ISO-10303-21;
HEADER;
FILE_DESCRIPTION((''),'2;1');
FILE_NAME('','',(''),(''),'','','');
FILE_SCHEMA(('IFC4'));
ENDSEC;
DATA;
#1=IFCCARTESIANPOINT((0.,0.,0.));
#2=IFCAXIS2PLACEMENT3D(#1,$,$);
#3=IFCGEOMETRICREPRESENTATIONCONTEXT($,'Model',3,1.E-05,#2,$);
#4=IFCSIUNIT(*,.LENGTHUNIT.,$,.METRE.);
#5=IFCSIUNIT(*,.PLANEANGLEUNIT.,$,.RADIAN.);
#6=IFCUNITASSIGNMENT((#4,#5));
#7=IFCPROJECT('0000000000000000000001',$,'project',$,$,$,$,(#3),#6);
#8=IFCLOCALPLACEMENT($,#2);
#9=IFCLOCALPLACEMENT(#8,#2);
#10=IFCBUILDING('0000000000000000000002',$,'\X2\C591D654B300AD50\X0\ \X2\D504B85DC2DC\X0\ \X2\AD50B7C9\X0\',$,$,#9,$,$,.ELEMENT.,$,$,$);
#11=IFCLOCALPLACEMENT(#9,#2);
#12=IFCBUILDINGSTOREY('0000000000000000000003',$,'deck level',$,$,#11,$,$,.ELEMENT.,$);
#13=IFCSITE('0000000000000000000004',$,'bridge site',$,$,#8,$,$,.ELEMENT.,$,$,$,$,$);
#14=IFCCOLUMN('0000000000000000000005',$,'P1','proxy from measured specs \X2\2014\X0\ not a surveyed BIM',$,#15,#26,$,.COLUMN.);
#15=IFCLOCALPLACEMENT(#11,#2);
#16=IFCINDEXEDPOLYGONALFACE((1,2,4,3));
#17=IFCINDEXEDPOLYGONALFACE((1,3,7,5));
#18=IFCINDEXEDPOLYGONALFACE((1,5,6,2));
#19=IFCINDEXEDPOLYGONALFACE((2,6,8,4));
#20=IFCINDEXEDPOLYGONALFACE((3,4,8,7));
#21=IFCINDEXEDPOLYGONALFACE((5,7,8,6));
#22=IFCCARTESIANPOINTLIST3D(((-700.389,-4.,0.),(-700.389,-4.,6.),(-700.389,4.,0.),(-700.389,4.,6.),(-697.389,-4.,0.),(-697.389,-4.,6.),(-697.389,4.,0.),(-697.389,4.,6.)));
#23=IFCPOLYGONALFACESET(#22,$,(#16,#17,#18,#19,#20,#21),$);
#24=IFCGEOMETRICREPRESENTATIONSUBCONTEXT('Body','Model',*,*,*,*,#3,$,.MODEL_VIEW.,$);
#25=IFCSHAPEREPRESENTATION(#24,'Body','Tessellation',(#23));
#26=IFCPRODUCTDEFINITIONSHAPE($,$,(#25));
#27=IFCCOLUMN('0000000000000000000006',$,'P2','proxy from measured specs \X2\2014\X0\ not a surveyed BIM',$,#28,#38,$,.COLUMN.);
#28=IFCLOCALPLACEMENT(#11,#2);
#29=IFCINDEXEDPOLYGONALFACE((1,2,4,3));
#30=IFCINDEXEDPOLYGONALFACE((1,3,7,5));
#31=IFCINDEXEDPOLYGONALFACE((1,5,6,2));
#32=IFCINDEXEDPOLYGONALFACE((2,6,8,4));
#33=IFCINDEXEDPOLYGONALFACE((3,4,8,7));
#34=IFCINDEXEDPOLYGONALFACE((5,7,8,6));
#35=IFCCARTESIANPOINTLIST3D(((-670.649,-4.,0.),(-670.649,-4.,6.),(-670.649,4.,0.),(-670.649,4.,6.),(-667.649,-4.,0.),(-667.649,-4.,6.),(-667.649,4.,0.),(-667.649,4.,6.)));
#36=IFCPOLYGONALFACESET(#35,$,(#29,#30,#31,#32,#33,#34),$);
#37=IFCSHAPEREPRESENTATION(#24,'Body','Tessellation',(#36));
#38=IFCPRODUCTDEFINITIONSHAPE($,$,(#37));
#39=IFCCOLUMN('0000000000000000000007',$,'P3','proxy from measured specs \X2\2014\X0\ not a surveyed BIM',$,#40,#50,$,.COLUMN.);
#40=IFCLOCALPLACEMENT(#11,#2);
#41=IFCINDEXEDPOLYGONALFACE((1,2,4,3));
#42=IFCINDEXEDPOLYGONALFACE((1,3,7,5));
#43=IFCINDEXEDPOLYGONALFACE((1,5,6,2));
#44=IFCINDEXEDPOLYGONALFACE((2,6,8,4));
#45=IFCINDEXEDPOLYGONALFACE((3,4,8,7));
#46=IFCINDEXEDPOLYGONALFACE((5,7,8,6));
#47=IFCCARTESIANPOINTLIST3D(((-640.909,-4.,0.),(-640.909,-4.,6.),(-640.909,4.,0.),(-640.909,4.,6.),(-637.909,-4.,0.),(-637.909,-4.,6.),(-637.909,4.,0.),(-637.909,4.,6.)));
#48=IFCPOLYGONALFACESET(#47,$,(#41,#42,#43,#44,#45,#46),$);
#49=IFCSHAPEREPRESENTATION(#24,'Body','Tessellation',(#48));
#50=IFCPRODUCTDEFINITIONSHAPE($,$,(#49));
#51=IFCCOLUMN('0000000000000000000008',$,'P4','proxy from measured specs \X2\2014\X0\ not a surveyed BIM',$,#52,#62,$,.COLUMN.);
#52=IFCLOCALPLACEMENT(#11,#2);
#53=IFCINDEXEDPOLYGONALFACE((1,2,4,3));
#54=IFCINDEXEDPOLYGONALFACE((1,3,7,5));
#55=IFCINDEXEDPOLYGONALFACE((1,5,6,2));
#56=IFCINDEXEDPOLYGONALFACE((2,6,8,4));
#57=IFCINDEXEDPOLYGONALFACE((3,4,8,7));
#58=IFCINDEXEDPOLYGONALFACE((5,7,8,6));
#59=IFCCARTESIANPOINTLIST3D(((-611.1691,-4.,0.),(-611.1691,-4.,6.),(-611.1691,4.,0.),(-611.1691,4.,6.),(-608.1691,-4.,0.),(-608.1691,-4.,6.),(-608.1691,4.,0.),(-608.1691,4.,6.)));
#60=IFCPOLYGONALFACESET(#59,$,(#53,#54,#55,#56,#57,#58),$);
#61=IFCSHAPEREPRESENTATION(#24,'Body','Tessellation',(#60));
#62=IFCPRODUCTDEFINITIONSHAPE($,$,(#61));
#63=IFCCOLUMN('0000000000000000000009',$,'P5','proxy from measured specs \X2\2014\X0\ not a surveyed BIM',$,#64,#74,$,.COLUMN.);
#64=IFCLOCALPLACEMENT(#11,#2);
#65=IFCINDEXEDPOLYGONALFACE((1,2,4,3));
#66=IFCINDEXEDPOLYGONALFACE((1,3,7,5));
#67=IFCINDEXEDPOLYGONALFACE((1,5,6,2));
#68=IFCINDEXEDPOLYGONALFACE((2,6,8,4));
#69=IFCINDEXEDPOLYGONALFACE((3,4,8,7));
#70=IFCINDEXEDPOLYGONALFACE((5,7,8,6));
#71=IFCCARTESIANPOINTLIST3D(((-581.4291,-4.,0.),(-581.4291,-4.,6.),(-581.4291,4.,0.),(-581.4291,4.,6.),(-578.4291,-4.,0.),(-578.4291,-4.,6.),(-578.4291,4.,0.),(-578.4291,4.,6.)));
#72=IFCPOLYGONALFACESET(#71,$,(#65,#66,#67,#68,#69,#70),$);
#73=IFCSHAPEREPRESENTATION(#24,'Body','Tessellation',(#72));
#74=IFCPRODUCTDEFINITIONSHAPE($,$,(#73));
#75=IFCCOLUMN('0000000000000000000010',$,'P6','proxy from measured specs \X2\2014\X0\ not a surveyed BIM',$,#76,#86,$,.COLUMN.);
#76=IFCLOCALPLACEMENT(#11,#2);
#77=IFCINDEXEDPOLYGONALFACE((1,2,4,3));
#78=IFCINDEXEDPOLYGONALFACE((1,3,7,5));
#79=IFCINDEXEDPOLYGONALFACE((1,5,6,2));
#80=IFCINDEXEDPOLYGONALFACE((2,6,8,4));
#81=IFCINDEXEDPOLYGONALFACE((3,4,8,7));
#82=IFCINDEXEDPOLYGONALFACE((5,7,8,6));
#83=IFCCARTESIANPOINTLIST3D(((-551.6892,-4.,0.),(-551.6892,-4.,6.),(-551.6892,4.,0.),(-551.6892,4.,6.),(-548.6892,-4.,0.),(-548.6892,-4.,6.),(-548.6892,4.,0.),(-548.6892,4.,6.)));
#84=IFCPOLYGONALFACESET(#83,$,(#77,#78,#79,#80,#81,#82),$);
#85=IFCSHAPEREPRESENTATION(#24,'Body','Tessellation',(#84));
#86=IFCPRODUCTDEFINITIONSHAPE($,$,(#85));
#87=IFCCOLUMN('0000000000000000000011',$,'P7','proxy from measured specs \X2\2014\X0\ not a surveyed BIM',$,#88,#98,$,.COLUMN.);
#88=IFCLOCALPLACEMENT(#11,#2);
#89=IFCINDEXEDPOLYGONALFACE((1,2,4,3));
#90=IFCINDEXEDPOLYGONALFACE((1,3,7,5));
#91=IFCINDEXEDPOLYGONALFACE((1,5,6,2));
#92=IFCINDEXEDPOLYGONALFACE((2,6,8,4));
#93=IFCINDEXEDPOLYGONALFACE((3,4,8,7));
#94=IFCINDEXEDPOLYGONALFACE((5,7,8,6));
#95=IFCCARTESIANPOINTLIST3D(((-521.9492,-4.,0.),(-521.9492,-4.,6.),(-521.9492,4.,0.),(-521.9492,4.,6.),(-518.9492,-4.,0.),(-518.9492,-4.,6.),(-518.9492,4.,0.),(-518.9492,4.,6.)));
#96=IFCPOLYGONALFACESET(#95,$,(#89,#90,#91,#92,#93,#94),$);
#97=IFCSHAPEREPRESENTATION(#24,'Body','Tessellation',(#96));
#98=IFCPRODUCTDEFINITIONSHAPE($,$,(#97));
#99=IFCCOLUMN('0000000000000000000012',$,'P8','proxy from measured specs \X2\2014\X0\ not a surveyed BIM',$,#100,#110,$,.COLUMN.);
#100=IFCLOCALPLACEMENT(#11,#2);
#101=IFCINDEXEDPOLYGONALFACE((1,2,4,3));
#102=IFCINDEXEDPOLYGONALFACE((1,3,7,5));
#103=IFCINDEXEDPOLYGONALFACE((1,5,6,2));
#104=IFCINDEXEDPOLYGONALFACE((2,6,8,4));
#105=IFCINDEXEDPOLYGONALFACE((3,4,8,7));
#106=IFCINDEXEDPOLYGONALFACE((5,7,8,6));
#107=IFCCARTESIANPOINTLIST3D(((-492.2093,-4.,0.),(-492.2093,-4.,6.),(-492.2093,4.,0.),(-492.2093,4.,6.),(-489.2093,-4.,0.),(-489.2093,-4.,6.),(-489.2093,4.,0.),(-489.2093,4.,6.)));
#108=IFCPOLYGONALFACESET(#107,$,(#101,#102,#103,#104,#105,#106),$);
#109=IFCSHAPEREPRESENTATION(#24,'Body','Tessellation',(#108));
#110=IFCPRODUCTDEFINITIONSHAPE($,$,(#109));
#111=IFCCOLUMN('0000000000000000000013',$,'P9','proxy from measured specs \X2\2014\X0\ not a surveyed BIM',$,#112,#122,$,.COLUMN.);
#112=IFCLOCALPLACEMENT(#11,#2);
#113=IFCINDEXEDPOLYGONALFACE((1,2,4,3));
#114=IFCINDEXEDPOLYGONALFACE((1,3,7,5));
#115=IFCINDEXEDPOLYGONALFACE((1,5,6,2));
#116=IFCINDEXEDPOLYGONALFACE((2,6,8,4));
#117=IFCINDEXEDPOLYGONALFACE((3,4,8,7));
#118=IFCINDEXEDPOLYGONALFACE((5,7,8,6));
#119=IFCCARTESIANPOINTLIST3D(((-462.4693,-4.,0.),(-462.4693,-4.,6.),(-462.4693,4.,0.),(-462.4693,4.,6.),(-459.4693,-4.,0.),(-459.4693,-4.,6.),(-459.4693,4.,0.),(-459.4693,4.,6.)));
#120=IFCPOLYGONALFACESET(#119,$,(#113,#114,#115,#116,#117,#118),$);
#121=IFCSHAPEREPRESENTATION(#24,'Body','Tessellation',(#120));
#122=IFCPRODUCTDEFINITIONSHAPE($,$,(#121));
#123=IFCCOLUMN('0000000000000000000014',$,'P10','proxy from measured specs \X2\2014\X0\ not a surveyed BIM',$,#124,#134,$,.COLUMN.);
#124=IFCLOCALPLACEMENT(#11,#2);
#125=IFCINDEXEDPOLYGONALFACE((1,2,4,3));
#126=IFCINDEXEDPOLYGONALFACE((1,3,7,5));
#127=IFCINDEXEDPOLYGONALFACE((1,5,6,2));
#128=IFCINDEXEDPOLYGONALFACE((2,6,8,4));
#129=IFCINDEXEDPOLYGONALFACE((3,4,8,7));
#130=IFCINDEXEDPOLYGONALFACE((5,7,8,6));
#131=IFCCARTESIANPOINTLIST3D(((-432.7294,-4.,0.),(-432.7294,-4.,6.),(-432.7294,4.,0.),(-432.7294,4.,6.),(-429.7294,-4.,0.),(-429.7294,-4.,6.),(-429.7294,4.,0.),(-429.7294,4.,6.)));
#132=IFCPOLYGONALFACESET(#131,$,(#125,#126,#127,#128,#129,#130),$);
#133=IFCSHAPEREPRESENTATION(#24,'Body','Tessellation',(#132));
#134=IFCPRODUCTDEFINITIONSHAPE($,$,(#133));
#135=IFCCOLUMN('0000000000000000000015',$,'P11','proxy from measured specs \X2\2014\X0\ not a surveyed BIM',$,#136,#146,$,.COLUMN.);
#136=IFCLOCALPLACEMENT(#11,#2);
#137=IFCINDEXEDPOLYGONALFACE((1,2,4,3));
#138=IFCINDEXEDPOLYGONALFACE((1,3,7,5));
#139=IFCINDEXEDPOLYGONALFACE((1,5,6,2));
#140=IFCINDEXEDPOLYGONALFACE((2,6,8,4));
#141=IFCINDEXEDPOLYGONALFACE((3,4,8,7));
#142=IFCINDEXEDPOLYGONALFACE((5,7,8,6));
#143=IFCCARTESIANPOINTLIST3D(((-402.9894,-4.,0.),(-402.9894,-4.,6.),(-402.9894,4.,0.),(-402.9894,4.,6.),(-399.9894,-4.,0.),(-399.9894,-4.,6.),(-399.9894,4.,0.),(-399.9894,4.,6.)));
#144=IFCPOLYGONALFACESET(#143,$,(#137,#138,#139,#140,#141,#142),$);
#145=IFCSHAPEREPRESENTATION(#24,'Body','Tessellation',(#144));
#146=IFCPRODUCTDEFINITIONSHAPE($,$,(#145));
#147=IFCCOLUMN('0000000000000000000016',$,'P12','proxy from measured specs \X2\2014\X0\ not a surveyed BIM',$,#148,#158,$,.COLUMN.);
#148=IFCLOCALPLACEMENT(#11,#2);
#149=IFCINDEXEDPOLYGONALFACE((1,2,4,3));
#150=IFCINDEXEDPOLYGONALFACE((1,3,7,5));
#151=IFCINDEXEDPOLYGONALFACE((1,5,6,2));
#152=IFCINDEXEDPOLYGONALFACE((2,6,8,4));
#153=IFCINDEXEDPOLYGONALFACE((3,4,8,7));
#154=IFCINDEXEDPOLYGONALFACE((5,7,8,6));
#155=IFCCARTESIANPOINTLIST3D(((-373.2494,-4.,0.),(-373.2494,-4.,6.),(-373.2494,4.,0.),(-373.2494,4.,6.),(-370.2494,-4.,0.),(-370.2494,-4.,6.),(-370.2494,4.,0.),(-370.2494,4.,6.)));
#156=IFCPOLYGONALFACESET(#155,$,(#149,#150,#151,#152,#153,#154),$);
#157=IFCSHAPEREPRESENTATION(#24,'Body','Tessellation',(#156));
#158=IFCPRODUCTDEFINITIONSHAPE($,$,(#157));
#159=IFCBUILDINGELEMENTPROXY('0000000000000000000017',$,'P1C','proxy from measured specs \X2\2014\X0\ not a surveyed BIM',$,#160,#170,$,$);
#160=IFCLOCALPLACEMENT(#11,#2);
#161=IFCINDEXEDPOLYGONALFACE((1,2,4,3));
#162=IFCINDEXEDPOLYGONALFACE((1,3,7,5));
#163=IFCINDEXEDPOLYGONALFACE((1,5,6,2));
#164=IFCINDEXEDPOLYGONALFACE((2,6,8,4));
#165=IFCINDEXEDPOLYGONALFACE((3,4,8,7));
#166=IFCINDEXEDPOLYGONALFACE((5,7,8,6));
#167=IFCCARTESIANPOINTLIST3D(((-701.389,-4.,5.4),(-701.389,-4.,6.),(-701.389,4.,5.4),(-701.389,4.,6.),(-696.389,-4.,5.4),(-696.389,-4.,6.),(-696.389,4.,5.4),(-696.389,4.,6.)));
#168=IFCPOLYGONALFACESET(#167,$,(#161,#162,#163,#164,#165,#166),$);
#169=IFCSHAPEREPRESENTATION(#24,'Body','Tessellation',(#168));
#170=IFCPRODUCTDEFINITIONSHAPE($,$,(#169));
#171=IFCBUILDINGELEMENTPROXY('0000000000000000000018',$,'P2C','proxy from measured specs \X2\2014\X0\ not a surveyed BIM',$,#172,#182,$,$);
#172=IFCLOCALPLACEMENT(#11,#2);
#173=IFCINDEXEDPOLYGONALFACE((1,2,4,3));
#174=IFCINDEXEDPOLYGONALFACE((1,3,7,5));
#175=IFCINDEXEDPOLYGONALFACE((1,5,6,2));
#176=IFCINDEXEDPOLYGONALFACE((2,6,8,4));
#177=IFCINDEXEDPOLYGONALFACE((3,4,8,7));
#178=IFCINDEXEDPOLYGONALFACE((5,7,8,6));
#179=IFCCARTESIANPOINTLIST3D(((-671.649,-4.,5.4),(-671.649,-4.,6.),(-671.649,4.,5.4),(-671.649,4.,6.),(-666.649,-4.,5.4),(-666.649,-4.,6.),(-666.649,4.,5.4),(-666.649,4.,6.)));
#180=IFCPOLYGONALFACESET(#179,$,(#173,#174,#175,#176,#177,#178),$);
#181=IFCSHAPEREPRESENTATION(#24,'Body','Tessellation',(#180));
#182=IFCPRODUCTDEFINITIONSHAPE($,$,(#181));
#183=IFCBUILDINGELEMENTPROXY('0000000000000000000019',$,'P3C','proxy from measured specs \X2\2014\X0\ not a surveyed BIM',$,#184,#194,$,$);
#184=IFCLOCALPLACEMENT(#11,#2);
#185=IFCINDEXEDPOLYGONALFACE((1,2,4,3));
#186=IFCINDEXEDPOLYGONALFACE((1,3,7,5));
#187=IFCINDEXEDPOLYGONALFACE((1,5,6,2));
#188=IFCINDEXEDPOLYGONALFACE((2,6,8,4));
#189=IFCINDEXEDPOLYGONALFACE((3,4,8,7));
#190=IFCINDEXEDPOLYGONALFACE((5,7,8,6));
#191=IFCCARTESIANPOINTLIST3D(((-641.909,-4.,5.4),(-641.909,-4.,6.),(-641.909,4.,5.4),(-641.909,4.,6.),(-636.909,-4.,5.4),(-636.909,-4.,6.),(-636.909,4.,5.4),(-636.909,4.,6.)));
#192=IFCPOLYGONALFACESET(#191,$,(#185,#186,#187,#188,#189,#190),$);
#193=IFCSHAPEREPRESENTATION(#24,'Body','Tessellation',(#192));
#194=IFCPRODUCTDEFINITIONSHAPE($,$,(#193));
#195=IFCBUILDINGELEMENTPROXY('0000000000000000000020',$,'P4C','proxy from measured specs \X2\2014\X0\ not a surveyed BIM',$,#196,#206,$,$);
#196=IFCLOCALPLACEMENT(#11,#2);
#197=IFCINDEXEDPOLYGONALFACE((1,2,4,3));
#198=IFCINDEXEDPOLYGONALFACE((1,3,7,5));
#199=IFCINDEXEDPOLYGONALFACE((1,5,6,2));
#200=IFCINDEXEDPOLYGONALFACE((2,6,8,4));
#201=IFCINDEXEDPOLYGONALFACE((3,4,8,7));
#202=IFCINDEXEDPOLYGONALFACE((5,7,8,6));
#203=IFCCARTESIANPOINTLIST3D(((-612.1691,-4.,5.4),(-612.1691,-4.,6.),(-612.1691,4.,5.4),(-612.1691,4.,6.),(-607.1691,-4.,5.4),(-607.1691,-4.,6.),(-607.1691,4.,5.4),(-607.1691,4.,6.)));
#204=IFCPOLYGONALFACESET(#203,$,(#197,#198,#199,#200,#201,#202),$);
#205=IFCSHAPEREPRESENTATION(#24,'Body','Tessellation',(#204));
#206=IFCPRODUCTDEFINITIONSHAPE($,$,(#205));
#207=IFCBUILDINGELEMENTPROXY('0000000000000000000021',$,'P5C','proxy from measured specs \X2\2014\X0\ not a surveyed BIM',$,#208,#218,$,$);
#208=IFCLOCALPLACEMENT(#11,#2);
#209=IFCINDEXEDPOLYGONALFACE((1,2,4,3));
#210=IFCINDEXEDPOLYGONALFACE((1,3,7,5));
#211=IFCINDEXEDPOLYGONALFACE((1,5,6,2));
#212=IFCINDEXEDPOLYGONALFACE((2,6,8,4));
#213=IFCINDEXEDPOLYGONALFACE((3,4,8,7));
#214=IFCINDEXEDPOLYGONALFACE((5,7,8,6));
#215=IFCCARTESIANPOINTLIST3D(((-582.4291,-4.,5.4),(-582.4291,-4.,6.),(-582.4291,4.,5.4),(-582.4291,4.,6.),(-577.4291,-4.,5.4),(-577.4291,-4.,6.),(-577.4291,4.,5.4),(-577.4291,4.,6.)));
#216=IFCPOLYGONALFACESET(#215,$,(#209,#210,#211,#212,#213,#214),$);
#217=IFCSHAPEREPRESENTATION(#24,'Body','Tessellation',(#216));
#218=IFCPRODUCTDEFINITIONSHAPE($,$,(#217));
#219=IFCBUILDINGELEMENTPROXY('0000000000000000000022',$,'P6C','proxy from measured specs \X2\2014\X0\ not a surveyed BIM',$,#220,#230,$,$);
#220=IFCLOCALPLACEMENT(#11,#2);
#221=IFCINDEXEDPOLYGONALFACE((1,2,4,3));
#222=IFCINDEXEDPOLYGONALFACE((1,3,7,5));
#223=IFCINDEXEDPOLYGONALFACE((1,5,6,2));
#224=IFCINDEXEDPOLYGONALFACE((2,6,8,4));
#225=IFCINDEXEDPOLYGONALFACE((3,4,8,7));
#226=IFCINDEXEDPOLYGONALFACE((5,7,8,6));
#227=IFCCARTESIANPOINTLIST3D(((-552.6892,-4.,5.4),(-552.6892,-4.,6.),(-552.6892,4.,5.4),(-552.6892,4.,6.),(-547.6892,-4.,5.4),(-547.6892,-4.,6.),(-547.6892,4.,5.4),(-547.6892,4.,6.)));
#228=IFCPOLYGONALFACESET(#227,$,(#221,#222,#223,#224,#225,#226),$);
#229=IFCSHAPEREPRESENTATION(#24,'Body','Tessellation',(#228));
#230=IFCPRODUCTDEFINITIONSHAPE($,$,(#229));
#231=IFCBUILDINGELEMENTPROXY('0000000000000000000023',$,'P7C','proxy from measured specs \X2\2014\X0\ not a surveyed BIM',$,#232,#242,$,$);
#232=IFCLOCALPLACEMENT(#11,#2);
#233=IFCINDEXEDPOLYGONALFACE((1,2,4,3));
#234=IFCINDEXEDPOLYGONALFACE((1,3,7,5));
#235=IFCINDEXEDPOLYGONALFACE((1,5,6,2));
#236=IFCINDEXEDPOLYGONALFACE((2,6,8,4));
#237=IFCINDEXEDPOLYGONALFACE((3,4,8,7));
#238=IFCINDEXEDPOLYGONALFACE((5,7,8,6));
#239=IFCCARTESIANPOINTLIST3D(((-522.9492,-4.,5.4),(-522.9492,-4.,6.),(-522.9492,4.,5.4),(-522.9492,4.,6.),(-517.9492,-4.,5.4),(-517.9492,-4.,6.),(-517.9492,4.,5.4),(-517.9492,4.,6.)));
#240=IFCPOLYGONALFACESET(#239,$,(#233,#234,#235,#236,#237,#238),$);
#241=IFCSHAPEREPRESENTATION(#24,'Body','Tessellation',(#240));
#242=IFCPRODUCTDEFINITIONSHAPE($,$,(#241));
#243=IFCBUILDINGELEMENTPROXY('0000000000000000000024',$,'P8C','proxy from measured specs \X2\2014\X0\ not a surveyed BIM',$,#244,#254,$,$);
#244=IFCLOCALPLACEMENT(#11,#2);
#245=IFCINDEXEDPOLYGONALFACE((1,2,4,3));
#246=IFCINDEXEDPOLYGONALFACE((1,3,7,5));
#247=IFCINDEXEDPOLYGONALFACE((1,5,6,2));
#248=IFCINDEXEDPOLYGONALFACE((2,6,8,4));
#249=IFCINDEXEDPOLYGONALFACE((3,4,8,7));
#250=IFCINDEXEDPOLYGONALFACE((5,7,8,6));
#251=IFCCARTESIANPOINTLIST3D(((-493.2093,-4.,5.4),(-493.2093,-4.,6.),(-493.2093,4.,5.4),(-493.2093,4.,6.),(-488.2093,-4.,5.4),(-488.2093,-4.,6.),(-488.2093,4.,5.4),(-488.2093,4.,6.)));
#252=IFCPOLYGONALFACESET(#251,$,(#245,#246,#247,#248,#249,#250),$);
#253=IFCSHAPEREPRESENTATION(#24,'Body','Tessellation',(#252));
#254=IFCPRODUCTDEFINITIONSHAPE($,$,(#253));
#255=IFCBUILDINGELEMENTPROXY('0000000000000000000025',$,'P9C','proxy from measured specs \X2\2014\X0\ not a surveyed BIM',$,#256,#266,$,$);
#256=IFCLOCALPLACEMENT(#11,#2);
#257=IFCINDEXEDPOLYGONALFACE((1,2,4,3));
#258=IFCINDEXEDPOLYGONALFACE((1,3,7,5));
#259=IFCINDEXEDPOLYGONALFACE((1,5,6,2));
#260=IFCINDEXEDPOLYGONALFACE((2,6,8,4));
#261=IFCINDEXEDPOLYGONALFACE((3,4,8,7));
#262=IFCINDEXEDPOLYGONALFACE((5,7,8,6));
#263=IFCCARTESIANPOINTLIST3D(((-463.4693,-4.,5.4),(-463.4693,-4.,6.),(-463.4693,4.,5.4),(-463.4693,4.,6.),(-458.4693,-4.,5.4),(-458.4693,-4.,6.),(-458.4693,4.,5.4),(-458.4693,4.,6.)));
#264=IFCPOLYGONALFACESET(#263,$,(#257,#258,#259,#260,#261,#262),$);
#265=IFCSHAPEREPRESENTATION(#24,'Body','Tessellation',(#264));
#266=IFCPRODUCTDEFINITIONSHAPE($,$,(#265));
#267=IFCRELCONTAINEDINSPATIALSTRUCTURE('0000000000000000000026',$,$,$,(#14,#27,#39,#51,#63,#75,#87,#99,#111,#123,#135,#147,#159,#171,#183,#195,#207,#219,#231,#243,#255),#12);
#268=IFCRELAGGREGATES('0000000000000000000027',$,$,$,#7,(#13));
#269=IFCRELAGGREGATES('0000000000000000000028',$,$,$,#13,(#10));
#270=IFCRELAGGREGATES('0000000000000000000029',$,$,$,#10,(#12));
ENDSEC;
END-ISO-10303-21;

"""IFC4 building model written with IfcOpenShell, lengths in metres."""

from ifc_helpers import new_model, si_unit, frame, origin, origin_2d, place, context, subcontext, project, spatial, rectangle, extrude, element, save


model = new_model("IFC4")

# Units and contexts
model_context = context("Model", 3, precision=1e-05, world=origin())
body_context = subcontext(model_context, "Body", "Model", "MODEL_VIEW")
ifc_project = project(units=[si_unit("LENGTHUNIT", "METRE"), si_unit("PLANEANGLEUNIT", "RADIAN")], contexts=[model_context])

# Site, building, storey
site_placement = place(None, origin())
site = spatial("IfcSite", under=ifc_project, at=site_placement, Name="bridge site", CompositionType="ELEMENT")
building_placement = place(site_placement, origin())
building = spatial("IfcBuilding", under=site, at=building_placement, Name="양화대교 프록시 교량", CompositionType="ELEMENT")
storey_placement = place(building_placement, origin())
storey = spatial("IfcBuildingStorey", under=building, at=storey_placement, Name="deck level", CompositionType="ELEMENT")

# Columns
for number, where, name in (
    (1, (-698.889, 0.0, 0.0), "P1"),
    (2, (-669.149, 0.0, 0.0), "P2"),
    (3, (-639.409, 0.0, 0.0), "P3"),
    (4, (-609.6691, 0.0, 0.0), "P4"),
    (5, (-579.9291, 0.0, 0.0), "P5"),
    (6, (-550.1892, 0.0, 0.0), "P6"),
    (7, (-520.4492, 0.0, 0.0), "P7"),
    (8, (-490.7093, 0.0, 0.0), "P8"),
    (9, (-460.9693, 0.0, 0.0), "P9"),
    (10, (-431.2294, 0.0, 0.0), "P10"),
    (11, (-401.4894, 0.0, 0.0), "P11"),
    (12, (-371.7494, 0.0, 0.0), "P12"),
):
    element("IfcColumn", number, at=place(storey_placement, frame(where)), inside=storey, Name=name, Description="proxy from measured specs — not a surveyed BIM", PredefinedType="COLUMN", context=body_context, shape_type="SweptSolid", body=[
        extrude(rectangle(XDim=3.0, YDim=8.0, at=origin_2d()), origin(), (0.0, 0.0, 1.0), 6.0),
    ])

# Building element proxies
for number, where, name in (
    (13, (-698.889, 0.0, 5.4), "P1C"),
    (14, (-669.149, 0.0, 5.4), "P2C"),
    (15, (-639.409, 0.0, 5.4), "P3C"),
    (16, (-609.6691, 0.0, 5.4), "P4C"),
    (17, (-579.9291, 0.0, 5.4), "P5C"),
    (18, (-550.1892, 0.0, 5.4), "P6C"),
    (19, (-520.4492, 0.0, 5.4), "P7C"),
    (20, (-490.7093, 0.0, 5.4), "P8C"),
    (21, (-460.9693, 0.0, 5.4), "P9C"),
):
    element("IfcBuildingElementProxy", number, at=place(storey_placement, frame(where)), inside=storey, Name=name, Description="proxy from measured specs — not a surveyed BIM", context=body_context, shape_type="SweptSolid", body=[
        extrude(rectangle(XDim=5.0, YDim=8.0, at=origin_2d()), origin(), (0.0, 0.0, 1.0), 0.6),
    ])

save(model, "model.ifc")
